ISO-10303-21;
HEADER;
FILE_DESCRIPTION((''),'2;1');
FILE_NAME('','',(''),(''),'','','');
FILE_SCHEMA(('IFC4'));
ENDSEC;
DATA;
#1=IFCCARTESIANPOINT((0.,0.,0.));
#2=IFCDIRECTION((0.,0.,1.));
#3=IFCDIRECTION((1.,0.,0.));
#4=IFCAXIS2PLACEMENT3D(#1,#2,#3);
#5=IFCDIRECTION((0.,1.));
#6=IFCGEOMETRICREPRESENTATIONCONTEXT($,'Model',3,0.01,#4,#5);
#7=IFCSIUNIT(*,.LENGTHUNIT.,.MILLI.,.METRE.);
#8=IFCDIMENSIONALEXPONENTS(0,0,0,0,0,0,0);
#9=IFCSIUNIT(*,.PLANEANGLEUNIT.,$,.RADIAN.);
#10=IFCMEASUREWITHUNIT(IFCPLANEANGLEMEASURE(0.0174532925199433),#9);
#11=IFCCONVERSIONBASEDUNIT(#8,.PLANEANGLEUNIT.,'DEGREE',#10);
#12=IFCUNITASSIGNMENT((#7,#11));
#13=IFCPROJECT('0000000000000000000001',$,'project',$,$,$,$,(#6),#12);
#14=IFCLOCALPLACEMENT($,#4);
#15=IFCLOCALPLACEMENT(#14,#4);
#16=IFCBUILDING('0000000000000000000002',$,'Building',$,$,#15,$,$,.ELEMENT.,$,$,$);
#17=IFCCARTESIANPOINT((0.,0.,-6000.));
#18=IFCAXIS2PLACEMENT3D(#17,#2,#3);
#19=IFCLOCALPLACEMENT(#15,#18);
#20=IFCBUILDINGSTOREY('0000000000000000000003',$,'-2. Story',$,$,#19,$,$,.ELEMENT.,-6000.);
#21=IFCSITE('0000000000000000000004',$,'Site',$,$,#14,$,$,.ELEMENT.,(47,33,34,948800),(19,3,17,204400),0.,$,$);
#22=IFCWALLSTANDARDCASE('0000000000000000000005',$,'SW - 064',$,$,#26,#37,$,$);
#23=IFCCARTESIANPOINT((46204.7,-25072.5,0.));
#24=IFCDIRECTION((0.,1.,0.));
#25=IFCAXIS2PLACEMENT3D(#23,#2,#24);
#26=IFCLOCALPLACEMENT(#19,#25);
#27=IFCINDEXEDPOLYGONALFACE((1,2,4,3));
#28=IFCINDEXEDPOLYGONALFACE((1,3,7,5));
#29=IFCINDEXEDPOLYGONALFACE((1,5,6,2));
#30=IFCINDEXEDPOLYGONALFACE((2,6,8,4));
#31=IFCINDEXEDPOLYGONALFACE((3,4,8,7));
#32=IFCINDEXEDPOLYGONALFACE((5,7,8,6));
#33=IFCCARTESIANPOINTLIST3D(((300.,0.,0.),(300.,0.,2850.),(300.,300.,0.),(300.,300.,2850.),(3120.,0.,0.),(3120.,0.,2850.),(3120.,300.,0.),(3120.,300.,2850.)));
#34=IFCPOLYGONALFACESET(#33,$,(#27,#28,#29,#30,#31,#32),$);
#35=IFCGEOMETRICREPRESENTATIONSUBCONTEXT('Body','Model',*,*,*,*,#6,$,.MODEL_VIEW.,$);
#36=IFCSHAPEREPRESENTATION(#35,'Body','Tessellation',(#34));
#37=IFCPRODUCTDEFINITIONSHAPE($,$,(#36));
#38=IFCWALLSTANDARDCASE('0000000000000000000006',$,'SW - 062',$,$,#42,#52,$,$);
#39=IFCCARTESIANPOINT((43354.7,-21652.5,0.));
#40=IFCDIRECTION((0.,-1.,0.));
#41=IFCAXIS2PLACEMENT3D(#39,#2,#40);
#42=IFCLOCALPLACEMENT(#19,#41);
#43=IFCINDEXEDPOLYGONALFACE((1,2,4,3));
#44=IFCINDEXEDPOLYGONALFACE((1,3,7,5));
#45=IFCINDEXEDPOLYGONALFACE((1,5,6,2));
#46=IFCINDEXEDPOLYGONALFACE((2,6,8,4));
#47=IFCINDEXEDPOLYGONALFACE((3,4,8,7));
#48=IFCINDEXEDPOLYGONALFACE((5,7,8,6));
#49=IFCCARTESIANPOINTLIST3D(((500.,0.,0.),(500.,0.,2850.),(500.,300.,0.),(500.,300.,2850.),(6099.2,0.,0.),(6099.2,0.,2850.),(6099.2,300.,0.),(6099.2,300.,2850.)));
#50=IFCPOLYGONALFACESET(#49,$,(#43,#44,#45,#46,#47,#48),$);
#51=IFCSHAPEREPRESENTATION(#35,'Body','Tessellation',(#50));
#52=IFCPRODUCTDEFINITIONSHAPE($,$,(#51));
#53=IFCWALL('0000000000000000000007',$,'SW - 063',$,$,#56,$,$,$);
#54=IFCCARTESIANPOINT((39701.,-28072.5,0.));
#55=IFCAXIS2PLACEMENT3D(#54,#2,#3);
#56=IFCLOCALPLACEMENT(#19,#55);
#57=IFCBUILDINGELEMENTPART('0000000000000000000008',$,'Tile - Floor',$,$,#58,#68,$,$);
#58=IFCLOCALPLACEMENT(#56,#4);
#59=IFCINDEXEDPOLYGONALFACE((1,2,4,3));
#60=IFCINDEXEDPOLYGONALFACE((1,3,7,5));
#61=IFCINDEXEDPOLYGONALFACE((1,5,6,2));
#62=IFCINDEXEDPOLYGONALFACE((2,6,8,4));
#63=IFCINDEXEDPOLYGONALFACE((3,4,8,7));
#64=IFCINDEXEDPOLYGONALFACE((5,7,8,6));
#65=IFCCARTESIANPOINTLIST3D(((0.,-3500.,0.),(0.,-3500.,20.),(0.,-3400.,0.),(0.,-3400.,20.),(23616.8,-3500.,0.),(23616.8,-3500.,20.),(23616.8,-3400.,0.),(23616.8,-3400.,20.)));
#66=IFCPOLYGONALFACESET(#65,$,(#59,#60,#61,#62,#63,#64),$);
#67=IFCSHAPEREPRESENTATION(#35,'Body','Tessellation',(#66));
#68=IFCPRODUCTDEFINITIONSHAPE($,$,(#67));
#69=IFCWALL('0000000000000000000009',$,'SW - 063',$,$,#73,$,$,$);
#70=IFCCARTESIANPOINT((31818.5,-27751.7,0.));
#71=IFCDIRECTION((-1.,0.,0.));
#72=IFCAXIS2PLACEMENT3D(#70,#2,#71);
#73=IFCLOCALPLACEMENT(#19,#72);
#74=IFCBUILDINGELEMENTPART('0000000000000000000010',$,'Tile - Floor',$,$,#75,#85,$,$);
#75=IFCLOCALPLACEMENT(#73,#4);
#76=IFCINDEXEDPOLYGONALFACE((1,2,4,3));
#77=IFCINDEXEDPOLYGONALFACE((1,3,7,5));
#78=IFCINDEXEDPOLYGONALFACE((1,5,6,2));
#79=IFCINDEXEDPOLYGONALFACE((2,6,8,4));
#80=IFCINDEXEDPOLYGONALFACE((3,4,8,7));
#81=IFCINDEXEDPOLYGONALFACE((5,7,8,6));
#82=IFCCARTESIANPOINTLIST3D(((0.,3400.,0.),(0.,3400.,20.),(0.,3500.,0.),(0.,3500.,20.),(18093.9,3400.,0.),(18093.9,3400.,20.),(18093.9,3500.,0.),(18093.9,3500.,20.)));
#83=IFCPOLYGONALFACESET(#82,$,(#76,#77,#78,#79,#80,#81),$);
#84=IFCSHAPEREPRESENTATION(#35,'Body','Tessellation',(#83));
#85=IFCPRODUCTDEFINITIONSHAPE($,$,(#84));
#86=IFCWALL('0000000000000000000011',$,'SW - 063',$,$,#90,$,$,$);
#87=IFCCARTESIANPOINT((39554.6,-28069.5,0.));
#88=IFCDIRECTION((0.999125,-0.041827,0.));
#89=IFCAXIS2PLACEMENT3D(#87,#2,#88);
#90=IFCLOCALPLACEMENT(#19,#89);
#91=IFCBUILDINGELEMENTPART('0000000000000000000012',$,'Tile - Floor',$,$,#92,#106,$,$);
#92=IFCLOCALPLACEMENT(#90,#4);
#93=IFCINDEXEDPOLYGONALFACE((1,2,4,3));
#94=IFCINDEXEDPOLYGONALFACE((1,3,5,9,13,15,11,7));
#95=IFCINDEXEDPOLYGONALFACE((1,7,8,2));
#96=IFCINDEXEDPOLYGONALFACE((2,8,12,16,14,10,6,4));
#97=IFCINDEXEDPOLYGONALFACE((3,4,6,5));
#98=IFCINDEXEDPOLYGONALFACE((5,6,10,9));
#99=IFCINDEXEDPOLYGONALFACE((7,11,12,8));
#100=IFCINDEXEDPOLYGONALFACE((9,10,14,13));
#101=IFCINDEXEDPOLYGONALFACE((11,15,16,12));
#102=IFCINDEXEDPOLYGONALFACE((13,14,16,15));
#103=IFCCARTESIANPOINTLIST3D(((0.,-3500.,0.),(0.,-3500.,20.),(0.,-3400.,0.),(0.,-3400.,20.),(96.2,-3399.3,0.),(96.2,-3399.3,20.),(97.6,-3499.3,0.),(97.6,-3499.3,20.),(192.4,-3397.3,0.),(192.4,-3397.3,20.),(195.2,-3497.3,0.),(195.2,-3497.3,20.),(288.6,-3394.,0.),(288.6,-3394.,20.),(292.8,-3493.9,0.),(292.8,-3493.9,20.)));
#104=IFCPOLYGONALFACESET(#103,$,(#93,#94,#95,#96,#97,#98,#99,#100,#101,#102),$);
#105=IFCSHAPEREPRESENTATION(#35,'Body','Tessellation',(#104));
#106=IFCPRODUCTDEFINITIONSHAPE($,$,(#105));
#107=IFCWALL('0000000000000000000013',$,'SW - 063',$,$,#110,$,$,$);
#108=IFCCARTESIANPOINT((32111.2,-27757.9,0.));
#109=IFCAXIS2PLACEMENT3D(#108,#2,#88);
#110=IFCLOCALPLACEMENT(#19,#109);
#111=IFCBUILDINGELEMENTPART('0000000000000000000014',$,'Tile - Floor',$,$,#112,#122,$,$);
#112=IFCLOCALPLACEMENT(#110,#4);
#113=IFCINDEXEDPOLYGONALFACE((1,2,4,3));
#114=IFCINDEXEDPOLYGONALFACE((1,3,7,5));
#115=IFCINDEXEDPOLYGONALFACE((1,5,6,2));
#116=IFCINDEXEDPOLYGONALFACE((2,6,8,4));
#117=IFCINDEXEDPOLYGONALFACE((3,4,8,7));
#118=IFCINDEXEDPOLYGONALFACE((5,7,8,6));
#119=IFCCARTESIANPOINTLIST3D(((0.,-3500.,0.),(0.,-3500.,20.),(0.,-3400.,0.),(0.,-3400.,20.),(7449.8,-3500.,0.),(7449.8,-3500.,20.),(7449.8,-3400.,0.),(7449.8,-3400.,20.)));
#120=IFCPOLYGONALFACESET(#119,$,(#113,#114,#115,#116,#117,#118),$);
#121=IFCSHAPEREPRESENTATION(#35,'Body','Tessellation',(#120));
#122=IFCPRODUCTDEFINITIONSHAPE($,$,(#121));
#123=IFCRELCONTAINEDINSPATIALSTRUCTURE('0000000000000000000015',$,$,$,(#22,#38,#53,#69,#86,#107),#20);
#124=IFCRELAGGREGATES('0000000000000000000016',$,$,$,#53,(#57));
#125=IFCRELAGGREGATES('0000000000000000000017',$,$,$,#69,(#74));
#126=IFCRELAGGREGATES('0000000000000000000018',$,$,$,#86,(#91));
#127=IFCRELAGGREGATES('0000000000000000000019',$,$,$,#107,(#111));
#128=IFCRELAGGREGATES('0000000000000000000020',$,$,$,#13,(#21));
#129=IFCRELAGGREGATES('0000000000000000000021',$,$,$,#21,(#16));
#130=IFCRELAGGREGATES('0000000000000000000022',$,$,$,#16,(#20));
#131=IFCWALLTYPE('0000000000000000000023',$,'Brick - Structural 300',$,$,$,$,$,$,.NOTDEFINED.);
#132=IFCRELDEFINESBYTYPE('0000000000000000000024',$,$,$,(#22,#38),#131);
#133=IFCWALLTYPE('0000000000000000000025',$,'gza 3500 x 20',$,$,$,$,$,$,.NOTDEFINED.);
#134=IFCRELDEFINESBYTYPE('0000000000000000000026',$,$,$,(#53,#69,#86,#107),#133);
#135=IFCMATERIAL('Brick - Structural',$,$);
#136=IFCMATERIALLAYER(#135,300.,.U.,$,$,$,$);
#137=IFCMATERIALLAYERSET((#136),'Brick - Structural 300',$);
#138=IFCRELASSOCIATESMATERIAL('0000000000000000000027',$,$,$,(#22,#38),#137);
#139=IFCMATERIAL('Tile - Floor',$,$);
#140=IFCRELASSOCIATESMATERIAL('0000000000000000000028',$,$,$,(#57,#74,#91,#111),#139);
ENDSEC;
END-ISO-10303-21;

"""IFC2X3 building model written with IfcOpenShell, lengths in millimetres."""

from ifc_helpers import new_model, entity, si_unit, converted_unit, direction, frame, origin_with_axes, place, context, subcontext, project, spatial, polyline, outline, extrude, material, layer, layer_set, layer_usage, type_object, element, aggregate, save


model = new_model("IFC2X3")

# Units and contexts
model_context = context("Model", 3, precision=0.01, world=origin_with_axes(), true_north=direction((0.0, 1.0)))
body_context = subcontext(model_context, "Body", "Model", "MODEL_VIEW")
ifc_project = project(units=[si_unit("LENGTHUNIT", "METRE", prefix="MILLI"), converted_unit("PLANEANGLEUNIT", "DEGREE", entity("IfcPlaneAngleMeasure", 0.0174532925199433), si_unit("PLANEANGLEUNIT", "RADIAN"), dimensions=[0, 0, 0, 0, 0, 0, 0])], contexts=[model_context])

# Site, building, storey
site_placement = place(None, origin_with_axes())
site = spatial("IfcSite", under=ifc_project, at=site_placement, Name="Site", CompositionType="ELEMENT", RefLatitude=(47, 33, 34, 948800), RefLongitude=(19, 3, 17, 204400), RefElevation=0.0)
building_placement = place(site_placement, origin_with_axes())
building = spatial("IfcBuilding", under=site, at=building_placement, Name="Building", CompositionType="ELEMENT")
storey_placement = place(building_placement, frame((0.0, 0.0, -6000.0), z_axis=(0.0, 0.0, 1.0), x_axis=(1.0, 0.0, 0.0)))
storey = spatial("IfcBuildingStorey", under=building, at=storey_placement, Name="-2. Story", CompositionType="ELEMENT", Elevation=-6000.0)

# Walls
ifc_material_1 = material(Name="Brick - Structural")
ifc_layer_1 = layer(ifc_material_1, 300.0, ventilated="UNKNOWN")
ifc_layer_set_1 = layer_set([ifc_layer_1], Name="Brick - Structural 300")
ifc_layer_usage_1 = layer_usage(ifc_layer_set_1, "AXIS2", "POSITIVE", 0.0)
wall_type_1 = type_object("IfcWallType", Name="Brick - Structural 300", PredefinedType="NOTDEFINED")
wall_1_placement = place(storey_placement, frame((46204.7, -25072.5, 0.0), z_axis=(0.0, 0.0, 1.0), x_axis=(0.0, 1.0, 0.0)))
element("IfcWallStandardCase", 1, at=wall_1_placement, inside=storey, type_object=wall_type_1, material=ifc_layer_usage_1, Name="SW - 064", context=body_context, shape_type="SweptSolid", body=[
    extrude(outline(polyline([(300.0, 0.0), (3120.0, 0.0), (3120.0, 300.0), (300.0, 300.0), (300.0, 0.0)])), origin_with_axes(), (0.0, 0.0, 1.0), 2850.0),
])
ifc_layer_usage_2 = layer_usage(ifc_layer_set_1, "AXIS2", "POSITIVE", 0.0)
wall_2_placement = place(storey_placement, frame((43354.7, -21652.5, 0.0), z_axis=(0.0, 0.0, 1.0), x_axis=(0.0, -1.0, 0.0)))
element("IfcWallStandardCase", 2, at=wall_2_placement, inside=storey, type_object=wall_type_1, material=ifc_layer_usage_2, Name="SW - 062", context=body_context, shape_type="SweptSolid", body=[
    extrude(outline(polyline([(500.0, 0.0), (6099.2, 0.0), (6099.2, 300.0), (500.0, 300.0), (500.0, 0.0)])), origin_with_axes(), (0.0, 0.0, 1.0), 2850.0),
])

# Walls, building element parts
wall_type_2 = type_object("IfcWallType", Name="gza 3500 x 20", PredefinedType="NOTDEFINED")
wall_3_placement = place(storey_placement, frame((39701.0, -28072.5, 0.0), z_axis=(0.0, 0.0, 1.0), x_axis=(1.0, 0.0, 0.0)))
wall_3 = element("IfcWall", 3, at=wall_3_placement, inside=storey, type_object=wall_type_2, Name="SW - 063")
ifc_material_2 = material(Name="Tile - Floor")
building_element_part_1_placement = place(wall_3_placement, origin_with_axes())
building_element_part_1 = element("IfcBuildingElementPart", 4, at=building_element_part_1_placement, material=ifc_material_2, Name="Tile - Floor", context=body_context, shape_type="SweptSolid", body=[
    extrude(outline(polyline([(3400.0, 20.0), (3400.0, 0.0), (3500.0, 0.0), (3500.0, 20.0), (3400.0, 20.0)])), frame((0.0, 0.0, 0.0), z_axis=(-1.0, 0.0, 0.0), x_axis=(0.0, -1.0, 0.0)), (0.0, 0.0, -1.0), 23616.8),
])
aggregate(wall_3, [building_element_part_1])
wall_4_placement = place(storey_placement, frame((31818.5, -27751.7, 0.0), z_axis=(0.0, 0.0, 1.0), x_axis=(-1.0, 0.0, 0.0)))
wall_4 = element("IfcWall", 5, at=wall_4_placement, inside=storey, type_object=wall_type_2, Name="SW - 063")
building_element_part_2_placement = place(wall_4_placement, origin_with_axes())
building_element_part_2 = element("IfcBuildingElementPart", 6, at=building_element_part_2_placement, material=ifc_material_2, Name="Tile - Floor", context=body_context, shape_type="SweptSolid", body=[
    extrude(outline(polyline([(3400.0, 20.0), (3400.0, 0.0), (3500.0, 0.0), (3500.0, 20.0), (3400.0, 20.0)])), frame((0.0, 0.0, 0.0), z_axis=(1.0, 0.0, 0.0), x_axis=(0.0, 1.0, 0.0)), (0.0, 0.0, 1.0), 18093.9),
])
aggregate(wall_4, [building_element_part_2])
wall_5_placement = place(storey_placement, frame((39554.6, -28069.5, 0.0), z_axis=(0.0, 0.0, 1.0), x_axis=(0.999125, -0.041827, 0.0)))
wall_5 = element("IfcWall", 7, at=wall_5_placement, inside=storey, type_object=wall_type_2, Name="SW - 063")
building_element_part_3_placement = place(wall_5_placement, origin_with_axes())
cartesian_point_1 = entity("IfcCartesianPoint", [3400.0, 20.0])
building_element_part_3 = element("IfcBuildingElementPart", 8, at=building_element_part_3_placement, material=ifc_material_2, Name="Tile - Floor", context=body_context, shape_type="SweptSolid", body=[
    entity("IfcRevolvedAreaSolid", entity("IfcArbitraryClosedProfileDef", "AREA", None, entity("IfcPolyline", [cartesian_point_1, entity("IfcCartesianPoint", [3400.0, 0.0]), entity("IfcCartesianPoint", [3500.0, 0.0]), entity("IfcCartesianPoint", [3500.0, 20.0]), cartesian_point_1])), entity("IfcAxis2Placement3D", entity("IfcCartesianPoint", [0.0, 0.0, 0.0]), entity("IfcDirection", [-1.0, 0.0, 0.0]), entity("IfcDirection", [0.0, -1.0, 0.0])), entity("IfcAxis1Placement", entity("IfcCartesianPoint", [-3500.0, 0.0, 0.0]), entity("IfcDirection", [0.0, 1.0, 0.0])), 2.397219),
])
aggregate(wall_5, [building_element_part_3])
wall_6_placement = place(storey_placement, frame((32111.2, -27757.9, 0.0), z_axis=(0.0, 0.0, 1.0), x_axis=(0.999125, -0.041827, 0.0)))
wall_6 = element("IfcWall", 9, at=wall_6_placement, inside=storey, type_object=wall_type_2, Name="SW - 063")
building_element_part_4_placement = place(wall_6_placement, origin_with_axes())
building_element_part_4 = element("IfcBuildingElementPart", 10, at=building_element_part_4_placement, material=ifc_material_2, Name="Tile - Floor", context=body_context, shape_type="SweptSolid", body=[
    extrude(outline(polyline([(3400.0, 20.0), (3400.0, 0.0), (3500.0, 0.0), (3500.0, 20.0), (3400.0, 20.0)])), frame((0.0, 0.0, 0.0), z_axis=(-1.0, 0.0, 0.0), x_axis=(0.0, -1.0, 0.0)), (0.0, 0.0, -1.0), 7449.8),
])
aggregate(wall_6, [building_element_part_4])

save(model, "model.ifc")
